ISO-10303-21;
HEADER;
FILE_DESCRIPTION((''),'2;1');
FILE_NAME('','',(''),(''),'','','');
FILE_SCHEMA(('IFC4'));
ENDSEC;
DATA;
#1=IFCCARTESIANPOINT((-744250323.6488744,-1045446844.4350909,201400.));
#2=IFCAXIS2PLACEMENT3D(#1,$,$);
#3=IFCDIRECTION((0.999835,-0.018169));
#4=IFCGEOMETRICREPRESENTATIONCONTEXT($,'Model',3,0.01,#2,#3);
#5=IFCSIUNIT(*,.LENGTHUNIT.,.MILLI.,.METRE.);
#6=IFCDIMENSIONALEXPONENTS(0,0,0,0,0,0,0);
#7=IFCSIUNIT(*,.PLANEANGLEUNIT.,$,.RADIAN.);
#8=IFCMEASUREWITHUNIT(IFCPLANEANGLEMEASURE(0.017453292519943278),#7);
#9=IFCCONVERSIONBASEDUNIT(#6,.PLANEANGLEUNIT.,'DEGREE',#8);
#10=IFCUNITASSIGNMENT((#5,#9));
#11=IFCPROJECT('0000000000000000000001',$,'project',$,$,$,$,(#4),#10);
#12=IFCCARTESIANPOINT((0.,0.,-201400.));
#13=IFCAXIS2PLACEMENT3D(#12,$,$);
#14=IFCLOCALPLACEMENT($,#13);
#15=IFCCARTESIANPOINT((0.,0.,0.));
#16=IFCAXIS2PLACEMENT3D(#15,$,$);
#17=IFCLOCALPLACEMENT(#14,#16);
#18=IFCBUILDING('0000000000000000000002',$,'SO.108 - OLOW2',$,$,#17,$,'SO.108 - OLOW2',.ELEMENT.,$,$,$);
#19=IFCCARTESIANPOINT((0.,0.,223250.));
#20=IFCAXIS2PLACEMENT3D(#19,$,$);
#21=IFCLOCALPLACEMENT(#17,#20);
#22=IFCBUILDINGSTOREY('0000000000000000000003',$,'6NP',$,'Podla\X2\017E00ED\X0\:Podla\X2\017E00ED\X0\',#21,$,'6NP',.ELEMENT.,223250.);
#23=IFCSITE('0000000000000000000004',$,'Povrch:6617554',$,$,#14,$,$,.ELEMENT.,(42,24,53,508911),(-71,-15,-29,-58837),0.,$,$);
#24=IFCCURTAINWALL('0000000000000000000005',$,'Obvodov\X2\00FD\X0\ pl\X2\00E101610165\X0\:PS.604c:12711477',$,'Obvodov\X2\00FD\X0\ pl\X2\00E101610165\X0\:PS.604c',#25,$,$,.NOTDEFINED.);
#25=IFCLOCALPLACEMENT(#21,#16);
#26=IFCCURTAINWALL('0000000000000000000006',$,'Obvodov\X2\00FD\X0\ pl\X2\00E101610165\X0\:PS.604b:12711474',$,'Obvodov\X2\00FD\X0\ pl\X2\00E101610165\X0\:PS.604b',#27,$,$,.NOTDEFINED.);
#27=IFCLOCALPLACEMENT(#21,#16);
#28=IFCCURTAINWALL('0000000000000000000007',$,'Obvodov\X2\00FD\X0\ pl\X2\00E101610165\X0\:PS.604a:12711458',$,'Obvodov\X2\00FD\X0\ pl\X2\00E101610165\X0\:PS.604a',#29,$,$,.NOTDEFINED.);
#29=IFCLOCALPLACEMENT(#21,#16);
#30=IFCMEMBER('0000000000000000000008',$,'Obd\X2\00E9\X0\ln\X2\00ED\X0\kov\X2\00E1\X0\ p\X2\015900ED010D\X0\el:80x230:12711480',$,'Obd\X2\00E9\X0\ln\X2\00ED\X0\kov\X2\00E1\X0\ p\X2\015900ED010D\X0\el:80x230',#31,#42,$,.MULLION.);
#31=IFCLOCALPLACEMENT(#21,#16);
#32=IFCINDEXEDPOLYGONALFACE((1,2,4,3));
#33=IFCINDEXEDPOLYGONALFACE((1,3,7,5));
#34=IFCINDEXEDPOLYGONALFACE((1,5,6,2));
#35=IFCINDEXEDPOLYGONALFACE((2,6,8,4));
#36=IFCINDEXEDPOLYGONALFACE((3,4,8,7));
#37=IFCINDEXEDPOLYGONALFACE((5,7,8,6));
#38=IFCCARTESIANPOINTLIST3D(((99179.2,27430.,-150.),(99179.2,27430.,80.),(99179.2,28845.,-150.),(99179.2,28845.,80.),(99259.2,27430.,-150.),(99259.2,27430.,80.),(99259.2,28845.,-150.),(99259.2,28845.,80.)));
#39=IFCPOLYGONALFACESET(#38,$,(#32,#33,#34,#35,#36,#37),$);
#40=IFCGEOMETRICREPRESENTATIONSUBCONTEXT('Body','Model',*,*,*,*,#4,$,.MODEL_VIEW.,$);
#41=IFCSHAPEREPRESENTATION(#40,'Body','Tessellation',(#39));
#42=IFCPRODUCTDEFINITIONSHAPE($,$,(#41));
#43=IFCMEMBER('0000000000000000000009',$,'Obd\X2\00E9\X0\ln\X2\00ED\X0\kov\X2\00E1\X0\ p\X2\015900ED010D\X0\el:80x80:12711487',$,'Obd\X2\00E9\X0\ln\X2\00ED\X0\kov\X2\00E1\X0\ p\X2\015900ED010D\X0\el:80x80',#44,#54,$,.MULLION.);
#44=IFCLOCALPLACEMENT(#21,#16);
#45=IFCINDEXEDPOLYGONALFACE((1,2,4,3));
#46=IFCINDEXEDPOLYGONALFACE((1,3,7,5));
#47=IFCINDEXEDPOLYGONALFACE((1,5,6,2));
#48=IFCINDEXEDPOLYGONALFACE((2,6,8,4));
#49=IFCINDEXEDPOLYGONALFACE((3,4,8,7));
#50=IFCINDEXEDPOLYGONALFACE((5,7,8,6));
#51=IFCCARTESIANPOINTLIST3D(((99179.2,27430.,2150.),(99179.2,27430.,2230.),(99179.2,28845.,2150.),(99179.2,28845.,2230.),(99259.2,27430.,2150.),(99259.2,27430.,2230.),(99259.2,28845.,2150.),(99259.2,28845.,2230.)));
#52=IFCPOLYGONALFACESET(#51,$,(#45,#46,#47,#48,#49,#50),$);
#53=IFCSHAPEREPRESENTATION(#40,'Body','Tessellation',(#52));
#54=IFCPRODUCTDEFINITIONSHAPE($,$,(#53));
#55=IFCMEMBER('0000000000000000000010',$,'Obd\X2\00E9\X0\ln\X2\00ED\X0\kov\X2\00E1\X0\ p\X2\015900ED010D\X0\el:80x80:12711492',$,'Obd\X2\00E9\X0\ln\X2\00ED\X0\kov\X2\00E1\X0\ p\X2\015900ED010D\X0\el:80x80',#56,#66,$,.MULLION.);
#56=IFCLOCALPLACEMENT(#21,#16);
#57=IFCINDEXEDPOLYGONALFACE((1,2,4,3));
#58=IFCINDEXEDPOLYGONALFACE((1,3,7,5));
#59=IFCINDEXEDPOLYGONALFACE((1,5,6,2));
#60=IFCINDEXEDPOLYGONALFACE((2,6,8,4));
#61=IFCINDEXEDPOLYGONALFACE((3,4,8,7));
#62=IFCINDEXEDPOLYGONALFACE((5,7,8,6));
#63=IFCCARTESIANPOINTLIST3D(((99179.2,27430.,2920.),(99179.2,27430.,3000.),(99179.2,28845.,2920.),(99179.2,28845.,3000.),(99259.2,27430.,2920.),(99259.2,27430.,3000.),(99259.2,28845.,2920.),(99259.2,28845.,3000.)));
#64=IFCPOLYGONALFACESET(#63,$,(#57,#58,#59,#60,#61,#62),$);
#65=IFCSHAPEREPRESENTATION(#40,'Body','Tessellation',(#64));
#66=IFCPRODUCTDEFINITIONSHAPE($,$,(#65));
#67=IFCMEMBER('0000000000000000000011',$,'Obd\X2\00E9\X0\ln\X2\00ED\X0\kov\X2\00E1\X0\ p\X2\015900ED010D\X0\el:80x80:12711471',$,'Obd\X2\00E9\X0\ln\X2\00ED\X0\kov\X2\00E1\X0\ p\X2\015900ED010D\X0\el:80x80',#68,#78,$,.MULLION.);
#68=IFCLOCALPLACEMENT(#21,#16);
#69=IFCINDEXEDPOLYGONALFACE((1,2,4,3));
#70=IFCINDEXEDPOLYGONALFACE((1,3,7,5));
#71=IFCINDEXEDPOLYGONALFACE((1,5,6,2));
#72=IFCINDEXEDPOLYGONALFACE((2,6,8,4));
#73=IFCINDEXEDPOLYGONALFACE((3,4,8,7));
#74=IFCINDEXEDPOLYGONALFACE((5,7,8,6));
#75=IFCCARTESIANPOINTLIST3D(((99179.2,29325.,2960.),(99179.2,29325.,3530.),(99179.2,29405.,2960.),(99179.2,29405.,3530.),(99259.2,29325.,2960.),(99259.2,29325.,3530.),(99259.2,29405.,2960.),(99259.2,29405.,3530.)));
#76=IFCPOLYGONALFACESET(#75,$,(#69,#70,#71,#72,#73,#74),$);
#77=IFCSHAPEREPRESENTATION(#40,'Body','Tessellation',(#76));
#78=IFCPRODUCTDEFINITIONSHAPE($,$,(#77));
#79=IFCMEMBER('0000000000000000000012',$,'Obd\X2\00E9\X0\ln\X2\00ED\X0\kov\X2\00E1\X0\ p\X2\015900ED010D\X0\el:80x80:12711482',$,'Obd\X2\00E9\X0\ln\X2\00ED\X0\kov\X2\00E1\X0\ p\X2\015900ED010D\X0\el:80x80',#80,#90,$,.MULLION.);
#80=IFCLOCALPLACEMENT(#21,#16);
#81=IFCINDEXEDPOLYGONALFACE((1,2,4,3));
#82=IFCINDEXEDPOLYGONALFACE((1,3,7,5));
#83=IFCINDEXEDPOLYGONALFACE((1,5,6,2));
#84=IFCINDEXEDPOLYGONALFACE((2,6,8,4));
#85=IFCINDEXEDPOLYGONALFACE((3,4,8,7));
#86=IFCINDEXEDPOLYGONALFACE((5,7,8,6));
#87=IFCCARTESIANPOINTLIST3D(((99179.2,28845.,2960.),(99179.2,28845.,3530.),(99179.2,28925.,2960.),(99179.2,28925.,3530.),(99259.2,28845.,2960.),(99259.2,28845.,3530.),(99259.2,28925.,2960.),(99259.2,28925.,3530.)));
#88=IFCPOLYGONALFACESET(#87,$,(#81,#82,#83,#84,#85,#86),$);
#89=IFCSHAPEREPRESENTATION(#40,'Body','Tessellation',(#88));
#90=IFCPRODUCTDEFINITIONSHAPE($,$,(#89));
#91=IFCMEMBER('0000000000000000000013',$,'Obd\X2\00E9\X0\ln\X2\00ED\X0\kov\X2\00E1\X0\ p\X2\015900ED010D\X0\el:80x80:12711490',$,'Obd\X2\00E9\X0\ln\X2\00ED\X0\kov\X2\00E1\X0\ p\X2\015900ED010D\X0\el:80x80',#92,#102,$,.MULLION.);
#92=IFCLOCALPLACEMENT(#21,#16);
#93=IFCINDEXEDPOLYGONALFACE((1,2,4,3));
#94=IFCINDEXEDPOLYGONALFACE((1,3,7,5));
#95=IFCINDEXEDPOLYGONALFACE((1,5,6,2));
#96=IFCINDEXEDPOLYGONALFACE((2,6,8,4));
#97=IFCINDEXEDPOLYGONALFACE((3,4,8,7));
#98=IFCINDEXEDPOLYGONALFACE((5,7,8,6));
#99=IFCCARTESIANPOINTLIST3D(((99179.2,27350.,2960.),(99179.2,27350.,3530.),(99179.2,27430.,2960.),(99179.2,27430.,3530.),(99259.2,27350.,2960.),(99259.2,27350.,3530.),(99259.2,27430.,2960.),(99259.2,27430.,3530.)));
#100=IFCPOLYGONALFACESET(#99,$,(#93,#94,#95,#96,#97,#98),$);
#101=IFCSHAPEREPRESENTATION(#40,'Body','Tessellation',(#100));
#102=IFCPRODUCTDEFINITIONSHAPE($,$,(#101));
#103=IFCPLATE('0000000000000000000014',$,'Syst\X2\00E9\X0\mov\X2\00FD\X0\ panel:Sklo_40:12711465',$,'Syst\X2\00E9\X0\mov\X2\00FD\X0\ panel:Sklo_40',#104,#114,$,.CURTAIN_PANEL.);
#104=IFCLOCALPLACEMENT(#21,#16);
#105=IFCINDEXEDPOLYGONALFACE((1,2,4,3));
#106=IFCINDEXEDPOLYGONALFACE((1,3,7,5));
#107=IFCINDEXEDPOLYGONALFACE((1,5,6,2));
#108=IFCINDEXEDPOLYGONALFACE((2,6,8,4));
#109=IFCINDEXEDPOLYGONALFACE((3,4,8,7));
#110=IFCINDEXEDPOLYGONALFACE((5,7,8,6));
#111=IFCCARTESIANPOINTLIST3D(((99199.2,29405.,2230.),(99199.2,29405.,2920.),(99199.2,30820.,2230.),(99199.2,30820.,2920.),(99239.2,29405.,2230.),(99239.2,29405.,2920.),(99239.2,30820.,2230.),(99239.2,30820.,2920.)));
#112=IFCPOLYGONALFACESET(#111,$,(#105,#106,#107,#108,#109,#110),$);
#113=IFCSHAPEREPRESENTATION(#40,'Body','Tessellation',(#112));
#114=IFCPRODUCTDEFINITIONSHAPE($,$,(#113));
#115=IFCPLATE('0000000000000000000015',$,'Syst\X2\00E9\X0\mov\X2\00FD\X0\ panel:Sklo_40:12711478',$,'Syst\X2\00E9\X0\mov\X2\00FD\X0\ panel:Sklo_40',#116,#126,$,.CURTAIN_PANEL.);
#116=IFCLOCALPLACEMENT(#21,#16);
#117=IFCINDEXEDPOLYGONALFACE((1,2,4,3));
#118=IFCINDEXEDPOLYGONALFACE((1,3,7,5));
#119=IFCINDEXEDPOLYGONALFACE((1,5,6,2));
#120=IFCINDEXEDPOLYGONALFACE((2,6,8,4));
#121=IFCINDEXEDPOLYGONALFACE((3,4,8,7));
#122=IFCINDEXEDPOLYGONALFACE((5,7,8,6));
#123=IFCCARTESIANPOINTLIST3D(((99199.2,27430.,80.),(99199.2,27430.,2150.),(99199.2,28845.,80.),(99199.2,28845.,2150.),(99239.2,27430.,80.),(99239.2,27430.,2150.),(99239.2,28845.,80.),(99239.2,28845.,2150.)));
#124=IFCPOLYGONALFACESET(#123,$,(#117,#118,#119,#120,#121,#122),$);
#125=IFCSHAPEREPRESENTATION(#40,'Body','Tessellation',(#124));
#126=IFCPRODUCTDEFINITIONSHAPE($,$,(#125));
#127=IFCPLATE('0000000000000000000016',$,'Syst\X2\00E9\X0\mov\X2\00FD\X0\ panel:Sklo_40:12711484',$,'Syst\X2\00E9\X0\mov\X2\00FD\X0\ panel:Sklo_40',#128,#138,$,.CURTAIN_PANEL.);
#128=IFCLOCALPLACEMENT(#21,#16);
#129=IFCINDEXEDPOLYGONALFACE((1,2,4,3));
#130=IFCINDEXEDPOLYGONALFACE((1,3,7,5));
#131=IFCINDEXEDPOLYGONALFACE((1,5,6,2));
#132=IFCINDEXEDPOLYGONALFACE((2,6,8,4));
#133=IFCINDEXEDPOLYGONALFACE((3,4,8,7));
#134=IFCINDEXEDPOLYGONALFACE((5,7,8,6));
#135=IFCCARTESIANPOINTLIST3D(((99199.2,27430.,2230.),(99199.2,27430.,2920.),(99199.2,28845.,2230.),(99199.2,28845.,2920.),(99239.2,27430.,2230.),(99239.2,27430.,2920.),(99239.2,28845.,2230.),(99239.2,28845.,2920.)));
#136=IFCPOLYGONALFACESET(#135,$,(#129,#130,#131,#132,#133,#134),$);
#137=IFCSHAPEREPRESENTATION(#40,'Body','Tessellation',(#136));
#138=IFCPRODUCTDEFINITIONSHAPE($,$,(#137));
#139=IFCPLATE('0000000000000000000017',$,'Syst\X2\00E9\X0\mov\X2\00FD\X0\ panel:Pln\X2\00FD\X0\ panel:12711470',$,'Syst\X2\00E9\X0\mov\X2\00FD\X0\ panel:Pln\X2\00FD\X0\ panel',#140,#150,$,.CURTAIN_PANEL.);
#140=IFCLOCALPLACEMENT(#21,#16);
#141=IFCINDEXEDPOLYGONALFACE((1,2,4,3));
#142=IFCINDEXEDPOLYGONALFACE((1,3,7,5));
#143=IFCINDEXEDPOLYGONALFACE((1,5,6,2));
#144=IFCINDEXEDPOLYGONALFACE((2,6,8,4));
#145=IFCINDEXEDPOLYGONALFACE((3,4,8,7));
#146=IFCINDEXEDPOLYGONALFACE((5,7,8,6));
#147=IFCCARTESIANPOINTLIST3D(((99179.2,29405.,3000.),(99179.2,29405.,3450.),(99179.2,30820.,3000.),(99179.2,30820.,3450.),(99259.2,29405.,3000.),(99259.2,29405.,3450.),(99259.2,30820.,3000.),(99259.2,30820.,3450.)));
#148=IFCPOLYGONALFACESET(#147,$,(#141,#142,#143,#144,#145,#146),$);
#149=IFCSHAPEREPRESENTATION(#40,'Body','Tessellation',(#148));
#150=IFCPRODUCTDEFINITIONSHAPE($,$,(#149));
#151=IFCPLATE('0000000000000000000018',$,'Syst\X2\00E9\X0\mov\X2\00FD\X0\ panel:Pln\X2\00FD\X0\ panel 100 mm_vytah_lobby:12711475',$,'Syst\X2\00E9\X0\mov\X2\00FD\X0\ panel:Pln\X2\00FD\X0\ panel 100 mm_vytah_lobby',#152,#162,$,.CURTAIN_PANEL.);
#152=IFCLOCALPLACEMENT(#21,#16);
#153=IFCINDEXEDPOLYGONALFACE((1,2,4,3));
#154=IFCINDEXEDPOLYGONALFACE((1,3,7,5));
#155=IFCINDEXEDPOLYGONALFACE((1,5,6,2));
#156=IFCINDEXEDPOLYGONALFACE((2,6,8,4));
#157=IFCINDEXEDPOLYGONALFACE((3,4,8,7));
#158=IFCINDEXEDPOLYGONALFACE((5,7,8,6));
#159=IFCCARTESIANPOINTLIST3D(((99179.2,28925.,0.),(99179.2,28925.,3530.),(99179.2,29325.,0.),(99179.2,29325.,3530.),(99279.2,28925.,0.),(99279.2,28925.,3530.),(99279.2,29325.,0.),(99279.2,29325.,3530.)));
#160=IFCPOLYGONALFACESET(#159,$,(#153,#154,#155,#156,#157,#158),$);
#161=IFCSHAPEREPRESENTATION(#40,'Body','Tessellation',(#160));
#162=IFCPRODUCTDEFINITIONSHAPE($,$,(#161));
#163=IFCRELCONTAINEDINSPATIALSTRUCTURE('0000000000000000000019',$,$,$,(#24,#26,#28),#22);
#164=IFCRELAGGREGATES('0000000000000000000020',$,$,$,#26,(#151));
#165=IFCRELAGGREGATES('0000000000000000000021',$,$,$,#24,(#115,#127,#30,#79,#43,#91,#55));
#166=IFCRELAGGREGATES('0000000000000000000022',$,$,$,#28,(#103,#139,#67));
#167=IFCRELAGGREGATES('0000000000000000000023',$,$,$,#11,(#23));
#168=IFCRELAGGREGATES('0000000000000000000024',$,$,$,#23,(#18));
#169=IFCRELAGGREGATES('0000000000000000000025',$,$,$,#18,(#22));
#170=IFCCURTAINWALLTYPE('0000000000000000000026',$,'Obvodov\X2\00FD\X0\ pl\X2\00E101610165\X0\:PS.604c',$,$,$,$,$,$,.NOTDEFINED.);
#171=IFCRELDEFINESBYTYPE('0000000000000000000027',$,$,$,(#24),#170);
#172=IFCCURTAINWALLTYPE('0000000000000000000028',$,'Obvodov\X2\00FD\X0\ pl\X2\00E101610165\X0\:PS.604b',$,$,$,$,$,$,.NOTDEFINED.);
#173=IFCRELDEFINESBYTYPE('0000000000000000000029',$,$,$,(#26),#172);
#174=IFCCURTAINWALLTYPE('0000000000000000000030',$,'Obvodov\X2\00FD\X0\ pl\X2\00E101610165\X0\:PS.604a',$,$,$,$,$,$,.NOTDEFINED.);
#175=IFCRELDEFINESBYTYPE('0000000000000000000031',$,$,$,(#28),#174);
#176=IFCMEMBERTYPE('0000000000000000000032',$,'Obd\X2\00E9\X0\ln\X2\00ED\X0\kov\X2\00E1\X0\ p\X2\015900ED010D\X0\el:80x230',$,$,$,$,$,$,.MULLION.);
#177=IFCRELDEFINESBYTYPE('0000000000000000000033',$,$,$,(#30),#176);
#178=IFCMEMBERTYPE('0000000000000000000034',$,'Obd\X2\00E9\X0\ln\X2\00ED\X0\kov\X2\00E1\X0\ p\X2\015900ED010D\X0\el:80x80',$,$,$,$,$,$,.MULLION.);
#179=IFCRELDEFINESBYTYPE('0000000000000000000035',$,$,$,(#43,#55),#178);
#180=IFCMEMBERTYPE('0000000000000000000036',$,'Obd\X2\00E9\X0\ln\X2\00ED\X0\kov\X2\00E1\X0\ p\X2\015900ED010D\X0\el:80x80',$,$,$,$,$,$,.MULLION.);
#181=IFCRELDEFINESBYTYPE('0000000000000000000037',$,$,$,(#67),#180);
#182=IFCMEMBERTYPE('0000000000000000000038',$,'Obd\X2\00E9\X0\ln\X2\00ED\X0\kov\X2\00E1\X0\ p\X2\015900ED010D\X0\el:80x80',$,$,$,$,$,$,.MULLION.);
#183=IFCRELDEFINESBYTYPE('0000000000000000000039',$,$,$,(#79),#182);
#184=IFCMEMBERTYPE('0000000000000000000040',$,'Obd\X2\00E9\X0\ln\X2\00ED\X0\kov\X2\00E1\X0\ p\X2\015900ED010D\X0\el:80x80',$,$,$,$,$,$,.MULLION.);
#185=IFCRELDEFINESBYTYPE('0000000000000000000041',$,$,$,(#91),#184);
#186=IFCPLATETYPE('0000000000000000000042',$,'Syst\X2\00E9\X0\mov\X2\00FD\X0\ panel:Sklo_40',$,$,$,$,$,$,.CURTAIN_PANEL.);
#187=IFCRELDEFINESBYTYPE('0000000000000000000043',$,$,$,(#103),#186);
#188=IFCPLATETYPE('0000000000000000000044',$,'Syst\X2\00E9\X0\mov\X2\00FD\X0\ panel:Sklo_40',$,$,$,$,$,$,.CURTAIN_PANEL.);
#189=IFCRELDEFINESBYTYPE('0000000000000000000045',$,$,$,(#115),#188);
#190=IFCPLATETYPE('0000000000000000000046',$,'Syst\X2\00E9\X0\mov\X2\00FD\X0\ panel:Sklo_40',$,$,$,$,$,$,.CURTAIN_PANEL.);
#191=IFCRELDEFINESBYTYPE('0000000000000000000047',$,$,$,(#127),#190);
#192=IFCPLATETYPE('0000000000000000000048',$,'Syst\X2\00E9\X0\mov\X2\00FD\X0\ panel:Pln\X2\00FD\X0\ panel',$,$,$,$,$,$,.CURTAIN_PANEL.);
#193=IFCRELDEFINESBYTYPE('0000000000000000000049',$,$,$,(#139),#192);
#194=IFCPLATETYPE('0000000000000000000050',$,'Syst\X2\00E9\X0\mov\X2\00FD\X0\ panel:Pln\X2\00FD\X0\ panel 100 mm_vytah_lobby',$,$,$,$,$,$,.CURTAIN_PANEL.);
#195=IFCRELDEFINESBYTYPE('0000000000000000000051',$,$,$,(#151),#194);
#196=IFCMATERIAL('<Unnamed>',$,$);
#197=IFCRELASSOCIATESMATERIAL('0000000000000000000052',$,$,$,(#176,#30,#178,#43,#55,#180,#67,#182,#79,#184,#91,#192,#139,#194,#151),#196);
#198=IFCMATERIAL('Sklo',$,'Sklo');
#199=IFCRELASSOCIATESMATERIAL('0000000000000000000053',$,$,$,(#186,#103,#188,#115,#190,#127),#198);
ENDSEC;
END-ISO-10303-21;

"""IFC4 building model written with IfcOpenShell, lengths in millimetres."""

from ifc_helpers import new_model, entity, si_unit, converted_unit, direction, frame, origin, place, context, subcontext, project, spatial, indexed_curve, outline, extrude, source, transform, mapped, material, type_object, type_shapes, element, aggregate, save


model = new_model("IFC4")

# Units and contexts
model_context = context("Model", 3, precision=0.01, world=frame((-744250323.6488744, -1045446844.4350909, 201400.0)), true_north=direction((0.999835, -0.018169)))
body_context = subcontext(model_context, "Body", "Model", "MODEL_VIEW")
ifc_project = project(units=[si_unit("LENGTHUNIT", "METRE", prefix="MILLI"), converted_unit("PLANEANGLEUNIT", "DEGREE", entity("IfcPlaneAngleMeasure", 0.017453292519943278), si_unit("PLANEANGLEUNIT", "RADIAN"), dimensions=[0, 0, 0, 0, 0, 0, 0])], contexts=[model_context])

# Site, building, storey
site_placement = place(None, frame((0.0, 0.0, -201400.0)))
site = spatial("IfcSite", under=ifc_project, at=site_placement, Name="Povrch:6617554", CompositionType="ELEMENT", RefLatitude=(42, 24, 53, 508911), RefLongitude=(-71, -15, -29, -58837), RefElevation=0.0)
building_placement = place(site_placement, origin())
building = spatial("IfcBuilding", under=site, at=building_placement, Name="SO.108 - OLOW2", LongName="SO.108 - OLOW2", CompositionType="ELEMENT")
storey_placement = place(building_placement, frame((0.0, 0.0, 223250.0)))
storey = spatial("IfcBuildingStorey", under=building, at=storey_placement, Name="6NP", ObjectType="Podlaží:Podlaží", LongName="6NP", CompositionType="ELEMENT", Elevation=223250.0)

# Curtain wall
curtain_wall_type_1 = type_object("IfcCurtainWallType", Name="Obvodový plášť:PS.604c", PredefinedType="NOTDEFINED")
curtain_wall_1_placement = place(storey_placement, frame((0.0, 0.0, -223250.0)))
curtain_wall_1 = element("IfcCurtainWall", 1, at=curtain_wall_1_placement, inside=storey, type_object=curtain_wall_type_1, Name="Obvodový plášť:PS.604c:12711477", ObjectType="Obvodový plášť:PS.604c", PredefinedType="NOTDEFINED")
ifc_material_1 = material(Name="<Unnamed>")

# Curtain wall
curtain_wall_type_2 = type_object("IfcCurtainWallType", Name="Obvodový plášť:PS.604b", PredefinedType="NOTDEFINED")
curtain_wall_2_placement = place(storey_placement, frame((0.0, 0.0, -223250.0)))
curtain_wall_2 = element("IfcCurtainWall", 2, at=curtain_wall_2_placement, inside=storey, type_object=curtain_wall_type_2, Name="Obvodový plášť:PS.604b:12711474", ObjectType="Obvodový plášť:PS.604b", PredefinedType="NOTDEFINED")

# Curtain wall
curtain_wall_type_3 = type_object("IfcCurtainWallType", Name="Obvodový plášť:PS.604a", PredefinedType="NOTDEFINED")
curtain_wall_3_placement = place(storey_placement, frame((0.0, 0.0, -223250.0)))
curtain_wall_3 = element("IfcCurtainWall", 3, at=curtain_wall_3_placement, inside=storey, type_object=curtain_wall_type_3, Name="Obvodový plášť:PS.604a:12711458", ObjectType="Obvodový plášť:PS.604a", PredefinedType="NOTDEFINED")

# Members
member_type_1 = type_object("IfcMemberType", Name="Obdélníková příčel:80x230", PredefinedType="MULLION", material=ifc_material_1)
shared_shape_1 = source(origin(), body_context, "Body", "SweptSolid", [
    extrude(outline(indexed_curve([(-115.0, -40.0), (115.0, -40.0), (115.0, 40.0), (-115.0, 40.0), (-115.0, -40.0)], self_intersect=False)), frame((-115.0, 0.0, -1415.0), z_axis=(0.0, 0.0, 1.0), x_axis=(-1.0, 0.0, 0.0)), (0.0, 0.0, 1.0), 1415.0),
])
type_shapes(member_type_1, [shared_shape_1])
member_1_placement = place(curtain_wall_1_placement, frame((99219.2, 28845.0, 223100.0), z_axis=(0.0, 1.0, 0.0), x_axis=(0.0, 0.0, -1.0)))
member_1 = element("IfcMember", 4, at=member_1_placement, type_object=member_type_1, material=ifc_material_1, Name="Obdélníková příčel:80x230:12711480", ObjectType="Obdélníková příčel:80x230", PredefinedType="MULLION", context=body_context, shape_type="MappedRepresentation", body=[
    mapped(shared_shape_1, transform((0.0, 0.0, 0.0), scale=1.0)),
])
member_type_2 = type_object("IfcMemberType", Name="Obdélníková příčel:80x80", PredefinedType="MULLION", material=ifc_material_1)
shared_shape_2 = source(origin(), body_context, "Body", "SweptSolid", [
    extrude(outline(indexed_curve([(-40.0, -40.0), (40.0, -40.0), (40.0, 40.0), (-40.0, 40.0), (-40.0, -40.0)], self_intersect=False)), frame((0.0, 0.0, -1415.0), z_axis=(0.0, 0.0, 1.0), x_axis=(-1.0, 0.0, 0.0)), (0.0, 0.0, 1.0), 1415.0),
])
type_shapes(member_type_2, [shared_shape_2])
member_2_placement = place(curtain_wall_1_placement, frame((99219.2, 27430.0, 225440.0), z_axis=(0.0, -1.0, 0.0), x_axis=(0.0, 0.0, 1.0)))
member_2 = element("IfcMember", 5, at=member_2_placement, type_object=member_type_2, material=ifc_material_1, Name="Obdélníková příčel:80x80:12711487", ObjectType="Obdélníková příčel:80x80", PredefinedType="MULLION", context=body_context, shape_type="MappedRepresentation", body=[
    mapped(shared_shape_2, transform((0.0, 0.0, 0.0), scale=1.0)),
])
member_3_placement = place(curtain_wall_1_placement, frame((99219.2, 27430.0, 226210.0), z_axis=(0.0, -1.0, 0.0), x_axis=(0.0, 0.0, 1.0)))
member_3 = element("IfcMember", 6, at=member_3_placement, type_object=member_type_2, material=ifc_material_1, Name="Obdélníková příčel:80x80:12711492", ObjectType="Obdélníková příčel:80x80", PredefinedType="MULLION", context=body_context, shape_type="MappedRepresentation", body=[
    mapped(shared_shape_2, transform((0.0, 0.0, 0.0), scale=1.0)),
])
member_type_3 = type_object("IfcMemberType", Name="Obdélníková příčel:80x80", PredefinedType="MULLION", material=ifc_material_1)
shared_shape_3 = source(origin(), body_context, "Body", "SweptSolid", [
    extrude(outline(indexed_curve([(-40.0, -40.0), (40.0, -40.0), (40.0, 40.0), (-40.0, 40.0), (-40.0, -40.0)], self_intersect=False)), frame((-40.0, 0.0, -570.0), z_axis=(0.0, 0.0, 1.0), x_axis=(-1.0, 0.0, 0.0)), (0.0, 0.0, 1.0), 570.0),
])
type_shapes(member_type_3, [shared_shape_3])
member_4_placement = place(curtain_wall_3_placement, frame((99219.2, 29325.0, 226210.0), z_axis=(0.0, 0.0, -1.0), x_axis=(0.0, -1.0, 0.0)))
member_4 = element("IfcMember", 7, at=member_4_placement, type_object=member_type_3, material=ifc_material_1, Name="Obdélníková příčel:80x80:12711471", ObjectType="Obdélníková příčel:80x80", PredefinedType="MULLION", context=body_context, shape_type="MappedRepresentation", body=[
    mapped(shared_shape_3, transform((0.0, 0.0, 0.0), scale=1.0)),
])
member_type_4 = type_object("IfcMemberType", Name="Obdélníková příčel:80x80", PredefinedType="MULLION", material=ifc_material_1)
shared_shape_4 = source(origin(), body_context, "Body", "SweptSolid", [
    extrude(outline(indexed_curve([(-40.0, -40.0), (40.0, -40.0), (40.0, 40.0), (-40.0, 40.0), (-40.0, -40.0)], self_intersect=False)), frame((-40.0, 0.0, -570.0), z_axis=(0.0, 0.0, 1.0), x_axis=(-1.0, 0.0, 0.0)), (0.0, 0.0, 1.0), 570.0),
])
type_shapes(member_type_4, [shared_shape_4])
member_5_placement = place(curtain_wall_1_placement, frame((99219.2, 28925.0, 226780.0), z_axis=(0.0, 0.0, 1.0), x_axis=(0.0, 1.0, 0.0)))
member_5 = element("IfcMember", 8, at=member_5_placement, type_object=member_type_4, material=ifc_material_1, Name="Obdélníková příčel:80x80:12711482", ObjectType="Obdélníková příčel:80x80", PredefinedType="MULLION", context=body_context, shape_type="MappedRepresentation", body=[
    mapped(shared_shape_4, transform((0.0, 0.0, 0.0), scale=1.0)),
])
member_type_5 = type_object("IfcMemberType", Name="Obdélníková příčel:80x80", PredefinedType="MULLION", material=ifc_material_1)
shared_shape_5 = source(origin(), body_context, "Body", "SweptSolid", [
    extrude(outline(indexed_curve([(-40.0, -40.0), (40.0, -40.0), (40.0, 40.0), (-40.0, 40.0), (-40.0, -40.0)], self_intersect=False)), frame((-40.0, 0.0, -570.0), z_axis=(0.0, 0.0, 1.0), x_axis=(-1.0, 0.0, 0.0)), (0.0, 0.0, 1.0), 570.0),
])
type_shapes(member_type_5, [shared_shape_5])
member_6_placement = place(curtain_wall_1_placement, frame((99219.2, 27350.0, 226210.0), z_axis=(0.0, 0.0, -1.0), x_axis=(0.0, -1.0, 0.0)))
member_6 = element("IfcMember", 9, at=member_6_placement, type_object=member_type_5, material=ifc_material_1, Name="Obdélníková příčel:80x80:12711490", ObjectType="Obdélníková příčel:80x80", PredefinedType="MULLION", context=body_context, shape_type="MappedRepresentation", body=[
    mapped(shared_shape_5, transform((0.0, 0.0, 0.0), scale=1.0)),
])

# Plates
ifc_material_2 = material(Name="Sklo", Category="Sklo")
plate_type_1 = type_object("IfcPlateType", Name="Systémový panel:Sklo_40", PredefinedType="CURTAIN_PANEL", material=ifc_material_2)
shared_shape_6 = source(origin(), body_context, "Body", "SweptSolid", [
    extrude(outline(indexed_curve([(-20.0, -707.5), (20.0, -707.5), (20.0, 707.5), (-20.0, 707.5), (-20.0, -707.5)], self_intersect=False)), frame((0.0, 0.0, 0.0), z_axis=(0.0, 0.0, 1.0), x_axis=(0.0, 1.0, 0.0)), (0.0, 0.0, 1.0), 690.0),
])
type_shapes(plate_type_1, [shared_shape_6])
plate_1_placement = place(curtain_wall_3_placement, frame((99219.2, 30112.5, 225480.0), z_axis=(0.0, 0.0, 1.0), x_axis=(0.0, -1.0, 0.0)))
plate_1 = element("IfcPlate", 10, at=plate_1_placement, type_object=plate_type_1, material=ifc_material_2, Name="Systémový panel:Sklo_40:12711465", ObjectType="Systémový panel:Sklo_40", PredefinedType="CURTAIN_PANEL", context=body_context, shape_type="MappedRepresentation", body=[
    mapped(shared_shape_6, transform((0.0, 0.0, 0.0), scale=1.0)),
])
plate_type_2 = type_object("IfcPlateType", Name="Systémový panel:Sklo_40", PredefinedType="CURTAIN_PANEL", material=ifc_material_2)
shared_shape_7 = source(origin(), body_context, "Body", "SweptSolid", [
    extrude(outline(indexed_curve([(-20.0, -707.5), (20.0, -707.5), (20.0, 707.5), (-20.0, 707.5), (-20.0, -707.5)], self_intersect=False)), frame((0.0, 0.0, 0.0), z_axis=(0.0, 0.0, 1.0), x_axis=(0.0, 1.0, 0.0)), (0.0, 0.0, 1.0), 2070.0),
])
type_shapes(plate_type_2, [shared_shape_7])
plate_2_placement = place(curtain_wall_1_placement, frame((99219.2, 28137.5, 223330.0), z_axis=(0.0, 0.0, 1.0), x_axis=(0.0, -1.0, 0.0)))
plate_2 = element("IfcPlate", 11, at=plate_2_placement, type_object=plate_type_2, material=ifc_material_2, Name="Systémový panel:Sklo_40:12711478", ObjectType="Systémový panel:Sklo_40", PredefinedType="CURTAIN_PANEL", context=body_context, shape_type="MappedRepresentation", body=[
    mapped(shared_shape_7, transform((0.0, 0.0, 0.0), scale=1.0)),
])
plate_type_3 = type_object("IfcPlateType", Name="Systémový panel:Sklo_40", PredefinedType="CURTAIN_PANEL", material=ifc_material_2)
shared_shape_8 = source(origin(), body_context, "Body", "SweptSolid", [
    extrude(outline(indexed_curve([(-20.0, -707.5), (20.0, -707.5), (20.0, 707.5), (-20.0, 707.5), (-20.0, -707.5)], self_intersect=False)), frame((0.0, 0.0, 0.0), z_axis=(0.0, 0.0, 1.0), x_axis=(0.0, 1.0, 0.0)), (0.0, 0.0, 1.0), 690.0),
])
type_shapes(plate_type_3, [shared_shape_8])
plate_3_placement = place(curtain_wall_1_placement, frame((99219.2, 28137.5, 225480.0), z_axis=(0.0, 0.0, 1.0), x_axis=(0.0, -1.0, 0.0)))
plate_3 = element("IfcPlate", 12, at=plate_3_placement, type_object=plate_type_3, material=ifc_material_2, Name="Systémový panel:Sklo_40:12711484", ObjectType="Systémový panel:Sklo_40", PredefinedType="CURTAIN_PANEL", context=body_context, shape_type="MappedRepresentation", body=[
    mapped(shared_shape_8, transform((0.0, 0.0, 0.0), scale=1.0)),
])
plate_type_4 = type_object("IfcPlateType", Name="Systémový panel:Plný panel", PredefinedType="CURTAIN_PANEL", material=ifc_material_1)
shared_shape_9 = source(origin(), body_context, "Body", "SweptSolid", [
    extrude(outline(indexed_curve([(-40.0, -707.5), (40.0, -707.5), (40.0, 707.5), (-40.0, 707.5), (-40.0, -707.5)], self_intersect=False)), frame((0.0, 0.0, 0.0), z_axis=(0.0, 0.0, 1.0), x_axis=(0.0, 1.0, 0.0)), (0.0, 0.0, 1.0), 450.0),
])
type_shapes(plate_type_4, [shared_shape_9])
plate_4_placement = place(curtain_wall_3_placement, frame((99219.2, 30112.5, 226250.0), z_axis=(0.0, 0.0, 1.0), x_axis=(0.0, -1.0, 0.0)))
plate_4 = element("IfcPlate", 13, at=plate_4_placement, type_object=plate_type_4, material=ifc_material_1, Name="Systémový panel:Plný panel:12711470", ObjectType="Systémový panel:Plný panel", PredefinedType="CURTAIN_PANEL", context=body_context, shape_type="MappedRepresentation", body=[
    mapped(shared_shape_9, transform((0.0, 0.0, 0.0), scale=1.0)),
])
plate_type_5 = type_object("IfcPlateType", Name="Systémový panel:Plný panel 100 mm_vytah_lobby", PredefinedType="CURTAIN_PANEL", material=ifc_material_1)
shared_shape_10 = source(origin(), body_context, "Body", "SweptSolid", [
    extrude(outline(indexed_curve([(-50.0, -200.0), (50.0, -200.0), (50.0, 200.0), (-50.0, 200.0), (-50.0, -200.0)], self_intersect=False)), frame((0.0, 10.0, 0.0), z_axis=(0.0, 0.0, 1.0), x_axis=(0.0, 1.0, 0.0)), (0.0, 0.0, 1.0), 3530.0),
])
type_shapes(plate_type_5, [shared_shape_10])
plate_5_placement = place(curtain_wall_2_placement, frame((99239.2, 29125.0, 223250.0), z_axis=(0.0, 0.0, 1.0), x_axis=(0.0, 1.0, 0.0)))
plate_5 = element("IfcPlate", 14, at=plate_5_placement, type_object=plate_type_5, material=ifc_material_1, Name="Systémový panel:Plný panel 100 mm_vytah_lobby:12711475", ObjectType="Systémový panel:Plný panel 100 mm_vytah_lobby", PredefinedType="CURTAIN_PANEL", context=body_context, shape_type="MappedRepresentation", body=[
    mapped(shared_shape_10, transform((0.0, 0.0, 0.0), scale=1.0)),
])
aggregate(curtain_wall_2, [plate_5])
aggregate(curtain_wall_1, [plate_2, plate_3, member_1, member_5, member_2, member_6, member_3])

aggregate(curtain_wall_3, [plate_1, plate_4, member_4])

save(model, "model.ifc")
